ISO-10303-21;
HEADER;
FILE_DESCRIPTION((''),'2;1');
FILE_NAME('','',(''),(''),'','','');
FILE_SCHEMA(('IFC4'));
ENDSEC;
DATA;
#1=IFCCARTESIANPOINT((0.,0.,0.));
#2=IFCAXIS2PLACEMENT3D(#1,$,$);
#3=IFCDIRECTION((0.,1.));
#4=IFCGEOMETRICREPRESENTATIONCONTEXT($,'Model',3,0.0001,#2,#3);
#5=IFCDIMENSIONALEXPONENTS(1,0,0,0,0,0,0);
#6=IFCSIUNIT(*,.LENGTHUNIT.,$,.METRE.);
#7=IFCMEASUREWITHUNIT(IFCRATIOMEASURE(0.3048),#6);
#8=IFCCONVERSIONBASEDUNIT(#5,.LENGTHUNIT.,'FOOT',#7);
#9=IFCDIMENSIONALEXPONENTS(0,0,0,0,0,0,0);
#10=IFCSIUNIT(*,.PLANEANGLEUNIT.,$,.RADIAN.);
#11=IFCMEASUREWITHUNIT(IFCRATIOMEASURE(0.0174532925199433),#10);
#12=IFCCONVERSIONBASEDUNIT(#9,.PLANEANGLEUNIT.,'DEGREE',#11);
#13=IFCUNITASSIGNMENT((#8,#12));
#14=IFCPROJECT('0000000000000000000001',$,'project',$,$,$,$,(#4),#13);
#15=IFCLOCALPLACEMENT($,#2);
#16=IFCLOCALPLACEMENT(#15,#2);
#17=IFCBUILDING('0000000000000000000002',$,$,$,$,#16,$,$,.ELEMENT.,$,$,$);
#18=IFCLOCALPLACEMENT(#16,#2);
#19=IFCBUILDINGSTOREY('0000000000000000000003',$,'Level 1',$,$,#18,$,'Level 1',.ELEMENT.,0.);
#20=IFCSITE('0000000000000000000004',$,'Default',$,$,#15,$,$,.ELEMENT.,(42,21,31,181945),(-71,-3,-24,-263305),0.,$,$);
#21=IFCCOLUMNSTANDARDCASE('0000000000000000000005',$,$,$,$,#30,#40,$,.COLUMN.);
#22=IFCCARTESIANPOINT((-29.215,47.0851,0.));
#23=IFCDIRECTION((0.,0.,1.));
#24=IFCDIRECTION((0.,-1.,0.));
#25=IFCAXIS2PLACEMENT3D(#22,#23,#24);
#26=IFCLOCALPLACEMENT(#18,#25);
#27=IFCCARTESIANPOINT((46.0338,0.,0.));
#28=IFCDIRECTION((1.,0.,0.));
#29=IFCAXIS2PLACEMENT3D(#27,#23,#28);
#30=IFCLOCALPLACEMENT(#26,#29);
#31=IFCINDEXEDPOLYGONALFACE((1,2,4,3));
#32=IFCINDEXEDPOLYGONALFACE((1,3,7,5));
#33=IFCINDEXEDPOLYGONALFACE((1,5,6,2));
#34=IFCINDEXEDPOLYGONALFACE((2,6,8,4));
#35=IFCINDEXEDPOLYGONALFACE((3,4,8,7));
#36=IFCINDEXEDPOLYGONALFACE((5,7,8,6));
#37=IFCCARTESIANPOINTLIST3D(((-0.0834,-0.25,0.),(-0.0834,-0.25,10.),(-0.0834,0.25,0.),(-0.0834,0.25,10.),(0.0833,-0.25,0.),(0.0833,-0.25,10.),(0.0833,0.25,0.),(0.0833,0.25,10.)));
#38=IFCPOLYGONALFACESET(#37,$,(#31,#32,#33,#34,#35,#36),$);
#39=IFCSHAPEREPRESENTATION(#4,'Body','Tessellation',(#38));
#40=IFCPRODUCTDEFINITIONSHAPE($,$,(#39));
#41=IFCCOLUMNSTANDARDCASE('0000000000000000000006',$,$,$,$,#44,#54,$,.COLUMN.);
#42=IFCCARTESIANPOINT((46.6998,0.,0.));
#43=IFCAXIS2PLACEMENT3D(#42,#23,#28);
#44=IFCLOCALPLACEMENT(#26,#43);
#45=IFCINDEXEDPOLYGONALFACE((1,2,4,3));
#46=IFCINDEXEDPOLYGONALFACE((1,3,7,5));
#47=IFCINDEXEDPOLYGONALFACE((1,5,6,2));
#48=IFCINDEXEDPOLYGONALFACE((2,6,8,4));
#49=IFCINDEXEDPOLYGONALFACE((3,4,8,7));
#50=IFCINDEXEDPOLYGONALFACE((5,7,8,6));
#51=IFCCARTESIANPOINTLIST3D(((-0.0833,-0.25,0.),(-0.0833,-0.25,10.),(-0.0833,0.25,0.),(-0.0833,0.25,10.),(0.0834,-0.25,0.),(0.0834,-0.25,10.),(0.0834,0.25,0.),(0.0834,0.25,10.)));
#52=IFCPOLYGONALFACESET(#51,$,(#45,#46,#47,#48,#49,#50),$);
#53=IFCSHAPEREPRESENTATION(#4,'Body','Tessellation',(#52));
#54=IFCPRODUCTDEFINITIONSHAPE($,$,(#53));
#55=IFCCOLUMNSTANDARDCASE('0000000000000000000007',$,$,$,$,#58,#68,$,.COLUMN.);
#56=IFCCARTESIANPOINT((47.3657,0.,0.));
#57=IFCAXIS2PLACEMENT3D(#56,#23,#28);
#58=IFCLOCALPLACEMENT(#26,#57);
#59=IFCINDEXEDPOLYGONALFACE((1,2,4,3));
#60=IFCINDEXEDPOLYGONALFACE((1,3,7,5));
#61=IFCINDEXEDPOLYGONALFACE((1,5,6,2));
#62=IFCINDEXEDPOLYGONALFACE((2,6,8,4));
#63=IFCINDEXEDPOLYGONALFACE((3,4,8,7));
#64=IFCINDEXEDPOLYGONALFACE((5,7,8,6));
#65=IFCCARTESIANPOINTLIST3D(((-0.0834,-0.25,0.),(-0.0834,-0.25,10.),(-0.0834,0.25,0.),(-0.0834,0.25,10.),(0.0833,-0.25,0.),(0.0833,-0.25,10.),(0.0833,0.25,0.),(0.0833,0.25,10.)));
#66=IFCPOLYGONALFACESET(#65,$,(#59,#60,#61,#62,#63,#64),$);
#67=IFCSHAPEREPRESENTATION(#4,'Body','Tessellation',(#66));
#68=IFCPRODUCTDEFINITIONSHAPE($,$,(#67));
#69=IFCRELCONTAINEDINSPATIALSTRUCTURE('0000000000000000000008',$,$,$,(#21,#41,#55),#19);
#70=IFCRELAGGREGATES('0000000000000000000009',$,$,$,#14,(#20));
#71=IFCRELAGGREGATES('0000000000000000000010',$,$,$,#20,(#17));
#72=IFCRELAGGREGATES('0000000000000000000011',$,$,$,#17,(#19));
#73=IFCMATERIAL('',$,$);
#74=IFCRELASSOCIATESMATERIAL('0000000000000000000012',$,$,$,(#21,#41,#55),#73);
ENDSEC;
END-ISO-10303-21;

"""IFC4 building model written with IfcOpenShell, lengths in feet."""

from ifc_helpers import new_model, entity, si_unit, converted_unit, direction, frame, origin, place, context, project, spatial, rectangle, extrude, material, element, save


model = new_model("IFC4")

# Units and contexts
model_context = context("Model", 3, precision=0.0001, world=origin(), true_north=direction((0.0, 1.0)))
ifc_project = project(units=[converted_unit("LENGTHUNIT", "FOOT", entity("IfcRatioMeasure", 0.3048), si_unit("LENGTHUNIT", "METRE"), dimensions=[1, 0, 0, 0, 0, 0, 0]), converted_unit("PLANEANGLEUNIT", "DEGREE", entity("IfcRatioMeasure", 0.0174532925199433), si_unit("PLANEANGLEUNIT", "RADIAN"), dimensions=[0, 0, 0, 0, 0, 0, 0])], contexts=[model_context])

# Site, building, storey
site_placement = place(None, origin())
site = spatial("IfcSite", under=ifc_project, at=site_placement, Name="Default", CompositionType="ELEMENT", RefLatitude=(42, 21, 31, 181945), RefLongitude=(-71, -3, -24, -263305), RefElevation=0.0)
building_placement = place(site_placement, origin())
building = spatial("IfcBuilding", under=site, at=building_placement, CompositionType="ELEMENT")
storey_placement = place(building_placement, origin())
storey = spatial("IfcBuildingStorey", under=building, at=storey_placement, Name="Level 1", LongName="Level 1", CompositionType="ELEMENT", Elevation=0.0)

# Columns
ifc_material_1 = material(Name="")
placement = place(storey_placement, frame((-29.215, 47.0851, 0.0), z_axis=(0.0, 0.0, 1.0), x_axis=(0.0, -1.0, 0.0)))
for number, where, z_axis, x_axis in (
    (1, (46.0338, 0.0, 0.0), (0.0, 0.0, 1.0), (1.0, 0.0, 0.0)),
    (2, (46.6998, 0.0, 0.0), (0.0, 0.0, 1.0), (1.0, 0.0, 0.0)),
    (3, (47.3657, 0.0, 0.0), (0.0, 0.0, 1.0), (1.0, 0.0, 0.0)),
):
    element("IfcColumnStandardCase", number, at=place(placement, frame(where, z_axis=z_axis, x_axis=x_axis)), inside=storey, material=ifc_material_1, PredefinedType="COLUMN", context=model_context, shape_type="SweptSolid", body=[
        extrude(rectangle(XDim=0.1667, YDim=0.5), origin(), (0.0, 0.0, 1.0), 10.0),
    ])

save(model, "model.ifc")
